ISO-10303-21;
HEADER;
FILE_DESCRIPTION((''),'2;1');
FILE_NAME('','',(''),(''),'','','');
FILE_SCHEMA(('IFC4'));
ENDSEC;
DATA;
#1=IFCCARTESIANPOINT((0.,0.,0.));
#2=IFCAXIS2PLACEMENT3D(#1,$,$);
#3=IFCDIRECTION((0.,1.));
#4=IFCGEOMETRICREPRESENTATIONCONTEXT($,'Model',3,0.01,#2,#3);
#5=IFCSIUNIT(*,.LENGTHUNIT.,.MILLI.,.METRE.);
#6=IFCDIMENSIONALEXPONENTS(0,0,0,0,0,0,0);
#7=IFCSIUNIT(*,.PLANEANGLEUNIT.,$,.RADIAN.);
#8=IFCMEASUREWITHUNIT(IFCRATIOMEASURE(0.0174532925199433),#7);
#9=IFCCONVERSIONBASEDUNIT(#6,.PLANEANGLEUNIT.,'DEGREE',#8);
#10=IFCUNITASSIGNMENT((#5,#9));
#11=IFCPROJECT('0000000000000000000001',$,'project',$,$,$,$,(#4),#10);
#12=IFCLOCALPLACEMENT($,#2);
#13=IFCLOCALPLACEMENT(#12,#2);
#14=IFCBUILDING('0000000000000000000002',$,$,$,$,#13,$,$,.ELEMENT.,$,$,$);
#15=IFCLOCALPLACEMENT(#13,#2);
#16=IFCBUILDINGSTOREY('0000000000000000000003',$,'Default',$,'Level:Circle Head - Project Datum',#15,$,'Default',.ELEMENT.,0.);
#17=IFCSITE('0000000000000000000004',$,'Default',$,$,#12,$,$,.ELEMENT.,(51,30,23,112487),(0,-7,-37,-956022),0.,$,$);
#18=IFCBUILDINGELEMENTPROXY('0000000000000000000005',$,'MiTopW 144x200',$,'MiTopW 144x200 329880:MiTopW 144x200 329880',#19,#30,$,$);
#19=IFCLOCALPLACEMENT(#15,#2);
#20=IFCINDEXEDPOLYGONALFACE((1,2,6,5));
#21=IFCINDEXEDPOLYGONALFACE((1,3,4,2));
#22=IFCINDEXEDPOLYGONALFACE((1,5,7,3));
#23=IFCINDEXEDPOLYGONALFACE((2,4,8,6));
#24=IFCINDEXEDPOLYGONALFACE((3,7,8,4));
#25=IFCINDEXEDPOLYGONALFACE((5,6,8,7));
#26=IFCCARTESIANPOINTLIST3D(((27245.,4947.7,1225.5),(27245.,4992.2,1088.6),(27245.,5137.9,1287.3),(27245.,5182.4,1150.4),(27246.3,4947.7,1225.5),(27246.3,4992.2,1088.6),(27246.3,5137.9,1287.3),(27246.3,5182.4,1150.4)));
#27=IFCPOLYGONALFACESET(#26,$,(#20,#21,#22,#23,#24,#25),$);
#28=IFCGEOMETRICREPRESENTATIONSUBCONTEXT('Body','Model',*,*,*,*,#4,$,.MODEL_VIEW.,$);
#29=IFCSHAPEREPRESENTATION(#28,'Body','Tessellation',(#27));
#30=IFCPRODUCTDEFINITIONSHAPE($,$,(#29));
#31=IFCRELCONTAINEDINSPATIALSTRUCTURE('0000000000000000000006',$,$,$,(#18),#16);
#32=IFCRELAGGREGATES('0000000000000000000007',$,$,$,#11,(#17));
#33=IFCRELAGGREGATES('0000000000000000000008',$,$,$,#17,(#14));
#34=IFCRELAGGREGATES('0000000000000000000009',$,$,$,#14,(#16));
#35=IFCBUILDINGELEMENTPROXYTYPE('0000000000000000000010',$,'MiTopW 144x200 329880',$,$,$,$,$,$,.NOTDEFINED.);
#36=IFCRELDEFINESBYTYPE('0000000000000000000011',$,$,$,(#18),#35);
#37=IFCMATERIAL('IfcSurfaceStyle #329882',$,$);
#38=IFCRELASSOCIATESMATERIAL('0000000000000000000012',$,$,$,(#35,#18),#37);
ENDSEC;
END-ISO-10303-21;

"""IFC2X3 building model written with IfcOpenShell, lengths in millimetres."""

from ifc_helpers import new_model, entity, si_unit, converted_unit, direction, frame, origin, place, context, subcontext, project, spatial, polyline, outline, extrude, source, transform, mapped, material, type_object, type_shapes, element, save


model = new_model("IFC2X3")

# Units and contexts
model_context = context("Model", 3, precision=0.01, world=origin(), true_north=direction((0.0, 1.0)))
body_context = subcontext(model_context, "Body", "Model", "MODEL_VIEW")
ifc_project = project(units=[si_unit("LENGTHUNIT", "METRE", prefix="MILLI"), converted_unit("PLANEANGLEUNIT", "DEGREE", entity("IfcRatioMeasure", 0.0174532925199433), si_unit("PLANEANGLEUNIT", "RADIAN"), dimensions=[0, 0, 0, 0, 0, 0, 0])], contexts=[model_context])

# Site, building, storey
site_placement = place(None, origin())
site = spatial("IfcSite", under=ifc_project, at=site_placement, Name="Default", CompositionType="ELEMENT", RefLatitude=(51, 30, 23, 112487), RefLongitude=(0, -7, -37, -956022), RefElevation=0.0)
building_placement = place(site_placement, origin())
building = spatial("IfcBuilding", under=site, at=building_placement, CompositionType="ELEMENT")
storey_placement = place(building_placement, origin())
storey = spatial("IfcBuildingStorey", under=building, at=storey_placement, Name="Default", ObjectType="Level:Circle Head - Project Datum", LongName="Default", CompositionType="ELEMENT", Elevation=0.0)

# Building element proxy
ifc_material_1 = material(Name="IfcSurfaceStyle #329882")
building_element_proxy_type_1 = type_object("IfcBuildingElementProxyType", Name="MiTopW 144x200 329880", PredefinedType="NOTDEFINED", material=ifc_material_1)
shared_shape_1 = source(origin(), body_context, "Body", "SweptSolid", [
    extrude(outline(polyline([(-100.0, -72.0), (100.0, -72.0), (100.0, 72.0), (-100.0, 72.0), (-100.0, -72.0)])), frame((100.0, 72.0, 0.0), z_axis=(0.0, 0.0, 1.0), x_axis=(-1.0, 0.0, 0.0)), (0.0, 0.0, 1.0), 1.3),
])
type_shapes(building_element_proxy_type_1, [shared_shape_1])
proxy_1_placement = place(building_placement, frame((27246.3, 4947.7, 1225.5), z_axis=(-1.0, 0.0, 0.0), x_axis=(0.0, 0.951057, 0.309017)))
element("IfcBuildingElementProxy", 1, at=proxy_1_placement, inside=storey, type_object=building_element_proxy_type_1, material=ifc_material_1, Name="MiTopW 144x200", ObjectType="MiTopW 144x200 329880:MiTopW 144x200 329880", context=body_context, shape_type="MappedRepresentation", body=[
    mapped(shared_shape_1, transform((0.0, 0.0, 0.0), scale=1.0)),
])

save(model, "model.ifc")
